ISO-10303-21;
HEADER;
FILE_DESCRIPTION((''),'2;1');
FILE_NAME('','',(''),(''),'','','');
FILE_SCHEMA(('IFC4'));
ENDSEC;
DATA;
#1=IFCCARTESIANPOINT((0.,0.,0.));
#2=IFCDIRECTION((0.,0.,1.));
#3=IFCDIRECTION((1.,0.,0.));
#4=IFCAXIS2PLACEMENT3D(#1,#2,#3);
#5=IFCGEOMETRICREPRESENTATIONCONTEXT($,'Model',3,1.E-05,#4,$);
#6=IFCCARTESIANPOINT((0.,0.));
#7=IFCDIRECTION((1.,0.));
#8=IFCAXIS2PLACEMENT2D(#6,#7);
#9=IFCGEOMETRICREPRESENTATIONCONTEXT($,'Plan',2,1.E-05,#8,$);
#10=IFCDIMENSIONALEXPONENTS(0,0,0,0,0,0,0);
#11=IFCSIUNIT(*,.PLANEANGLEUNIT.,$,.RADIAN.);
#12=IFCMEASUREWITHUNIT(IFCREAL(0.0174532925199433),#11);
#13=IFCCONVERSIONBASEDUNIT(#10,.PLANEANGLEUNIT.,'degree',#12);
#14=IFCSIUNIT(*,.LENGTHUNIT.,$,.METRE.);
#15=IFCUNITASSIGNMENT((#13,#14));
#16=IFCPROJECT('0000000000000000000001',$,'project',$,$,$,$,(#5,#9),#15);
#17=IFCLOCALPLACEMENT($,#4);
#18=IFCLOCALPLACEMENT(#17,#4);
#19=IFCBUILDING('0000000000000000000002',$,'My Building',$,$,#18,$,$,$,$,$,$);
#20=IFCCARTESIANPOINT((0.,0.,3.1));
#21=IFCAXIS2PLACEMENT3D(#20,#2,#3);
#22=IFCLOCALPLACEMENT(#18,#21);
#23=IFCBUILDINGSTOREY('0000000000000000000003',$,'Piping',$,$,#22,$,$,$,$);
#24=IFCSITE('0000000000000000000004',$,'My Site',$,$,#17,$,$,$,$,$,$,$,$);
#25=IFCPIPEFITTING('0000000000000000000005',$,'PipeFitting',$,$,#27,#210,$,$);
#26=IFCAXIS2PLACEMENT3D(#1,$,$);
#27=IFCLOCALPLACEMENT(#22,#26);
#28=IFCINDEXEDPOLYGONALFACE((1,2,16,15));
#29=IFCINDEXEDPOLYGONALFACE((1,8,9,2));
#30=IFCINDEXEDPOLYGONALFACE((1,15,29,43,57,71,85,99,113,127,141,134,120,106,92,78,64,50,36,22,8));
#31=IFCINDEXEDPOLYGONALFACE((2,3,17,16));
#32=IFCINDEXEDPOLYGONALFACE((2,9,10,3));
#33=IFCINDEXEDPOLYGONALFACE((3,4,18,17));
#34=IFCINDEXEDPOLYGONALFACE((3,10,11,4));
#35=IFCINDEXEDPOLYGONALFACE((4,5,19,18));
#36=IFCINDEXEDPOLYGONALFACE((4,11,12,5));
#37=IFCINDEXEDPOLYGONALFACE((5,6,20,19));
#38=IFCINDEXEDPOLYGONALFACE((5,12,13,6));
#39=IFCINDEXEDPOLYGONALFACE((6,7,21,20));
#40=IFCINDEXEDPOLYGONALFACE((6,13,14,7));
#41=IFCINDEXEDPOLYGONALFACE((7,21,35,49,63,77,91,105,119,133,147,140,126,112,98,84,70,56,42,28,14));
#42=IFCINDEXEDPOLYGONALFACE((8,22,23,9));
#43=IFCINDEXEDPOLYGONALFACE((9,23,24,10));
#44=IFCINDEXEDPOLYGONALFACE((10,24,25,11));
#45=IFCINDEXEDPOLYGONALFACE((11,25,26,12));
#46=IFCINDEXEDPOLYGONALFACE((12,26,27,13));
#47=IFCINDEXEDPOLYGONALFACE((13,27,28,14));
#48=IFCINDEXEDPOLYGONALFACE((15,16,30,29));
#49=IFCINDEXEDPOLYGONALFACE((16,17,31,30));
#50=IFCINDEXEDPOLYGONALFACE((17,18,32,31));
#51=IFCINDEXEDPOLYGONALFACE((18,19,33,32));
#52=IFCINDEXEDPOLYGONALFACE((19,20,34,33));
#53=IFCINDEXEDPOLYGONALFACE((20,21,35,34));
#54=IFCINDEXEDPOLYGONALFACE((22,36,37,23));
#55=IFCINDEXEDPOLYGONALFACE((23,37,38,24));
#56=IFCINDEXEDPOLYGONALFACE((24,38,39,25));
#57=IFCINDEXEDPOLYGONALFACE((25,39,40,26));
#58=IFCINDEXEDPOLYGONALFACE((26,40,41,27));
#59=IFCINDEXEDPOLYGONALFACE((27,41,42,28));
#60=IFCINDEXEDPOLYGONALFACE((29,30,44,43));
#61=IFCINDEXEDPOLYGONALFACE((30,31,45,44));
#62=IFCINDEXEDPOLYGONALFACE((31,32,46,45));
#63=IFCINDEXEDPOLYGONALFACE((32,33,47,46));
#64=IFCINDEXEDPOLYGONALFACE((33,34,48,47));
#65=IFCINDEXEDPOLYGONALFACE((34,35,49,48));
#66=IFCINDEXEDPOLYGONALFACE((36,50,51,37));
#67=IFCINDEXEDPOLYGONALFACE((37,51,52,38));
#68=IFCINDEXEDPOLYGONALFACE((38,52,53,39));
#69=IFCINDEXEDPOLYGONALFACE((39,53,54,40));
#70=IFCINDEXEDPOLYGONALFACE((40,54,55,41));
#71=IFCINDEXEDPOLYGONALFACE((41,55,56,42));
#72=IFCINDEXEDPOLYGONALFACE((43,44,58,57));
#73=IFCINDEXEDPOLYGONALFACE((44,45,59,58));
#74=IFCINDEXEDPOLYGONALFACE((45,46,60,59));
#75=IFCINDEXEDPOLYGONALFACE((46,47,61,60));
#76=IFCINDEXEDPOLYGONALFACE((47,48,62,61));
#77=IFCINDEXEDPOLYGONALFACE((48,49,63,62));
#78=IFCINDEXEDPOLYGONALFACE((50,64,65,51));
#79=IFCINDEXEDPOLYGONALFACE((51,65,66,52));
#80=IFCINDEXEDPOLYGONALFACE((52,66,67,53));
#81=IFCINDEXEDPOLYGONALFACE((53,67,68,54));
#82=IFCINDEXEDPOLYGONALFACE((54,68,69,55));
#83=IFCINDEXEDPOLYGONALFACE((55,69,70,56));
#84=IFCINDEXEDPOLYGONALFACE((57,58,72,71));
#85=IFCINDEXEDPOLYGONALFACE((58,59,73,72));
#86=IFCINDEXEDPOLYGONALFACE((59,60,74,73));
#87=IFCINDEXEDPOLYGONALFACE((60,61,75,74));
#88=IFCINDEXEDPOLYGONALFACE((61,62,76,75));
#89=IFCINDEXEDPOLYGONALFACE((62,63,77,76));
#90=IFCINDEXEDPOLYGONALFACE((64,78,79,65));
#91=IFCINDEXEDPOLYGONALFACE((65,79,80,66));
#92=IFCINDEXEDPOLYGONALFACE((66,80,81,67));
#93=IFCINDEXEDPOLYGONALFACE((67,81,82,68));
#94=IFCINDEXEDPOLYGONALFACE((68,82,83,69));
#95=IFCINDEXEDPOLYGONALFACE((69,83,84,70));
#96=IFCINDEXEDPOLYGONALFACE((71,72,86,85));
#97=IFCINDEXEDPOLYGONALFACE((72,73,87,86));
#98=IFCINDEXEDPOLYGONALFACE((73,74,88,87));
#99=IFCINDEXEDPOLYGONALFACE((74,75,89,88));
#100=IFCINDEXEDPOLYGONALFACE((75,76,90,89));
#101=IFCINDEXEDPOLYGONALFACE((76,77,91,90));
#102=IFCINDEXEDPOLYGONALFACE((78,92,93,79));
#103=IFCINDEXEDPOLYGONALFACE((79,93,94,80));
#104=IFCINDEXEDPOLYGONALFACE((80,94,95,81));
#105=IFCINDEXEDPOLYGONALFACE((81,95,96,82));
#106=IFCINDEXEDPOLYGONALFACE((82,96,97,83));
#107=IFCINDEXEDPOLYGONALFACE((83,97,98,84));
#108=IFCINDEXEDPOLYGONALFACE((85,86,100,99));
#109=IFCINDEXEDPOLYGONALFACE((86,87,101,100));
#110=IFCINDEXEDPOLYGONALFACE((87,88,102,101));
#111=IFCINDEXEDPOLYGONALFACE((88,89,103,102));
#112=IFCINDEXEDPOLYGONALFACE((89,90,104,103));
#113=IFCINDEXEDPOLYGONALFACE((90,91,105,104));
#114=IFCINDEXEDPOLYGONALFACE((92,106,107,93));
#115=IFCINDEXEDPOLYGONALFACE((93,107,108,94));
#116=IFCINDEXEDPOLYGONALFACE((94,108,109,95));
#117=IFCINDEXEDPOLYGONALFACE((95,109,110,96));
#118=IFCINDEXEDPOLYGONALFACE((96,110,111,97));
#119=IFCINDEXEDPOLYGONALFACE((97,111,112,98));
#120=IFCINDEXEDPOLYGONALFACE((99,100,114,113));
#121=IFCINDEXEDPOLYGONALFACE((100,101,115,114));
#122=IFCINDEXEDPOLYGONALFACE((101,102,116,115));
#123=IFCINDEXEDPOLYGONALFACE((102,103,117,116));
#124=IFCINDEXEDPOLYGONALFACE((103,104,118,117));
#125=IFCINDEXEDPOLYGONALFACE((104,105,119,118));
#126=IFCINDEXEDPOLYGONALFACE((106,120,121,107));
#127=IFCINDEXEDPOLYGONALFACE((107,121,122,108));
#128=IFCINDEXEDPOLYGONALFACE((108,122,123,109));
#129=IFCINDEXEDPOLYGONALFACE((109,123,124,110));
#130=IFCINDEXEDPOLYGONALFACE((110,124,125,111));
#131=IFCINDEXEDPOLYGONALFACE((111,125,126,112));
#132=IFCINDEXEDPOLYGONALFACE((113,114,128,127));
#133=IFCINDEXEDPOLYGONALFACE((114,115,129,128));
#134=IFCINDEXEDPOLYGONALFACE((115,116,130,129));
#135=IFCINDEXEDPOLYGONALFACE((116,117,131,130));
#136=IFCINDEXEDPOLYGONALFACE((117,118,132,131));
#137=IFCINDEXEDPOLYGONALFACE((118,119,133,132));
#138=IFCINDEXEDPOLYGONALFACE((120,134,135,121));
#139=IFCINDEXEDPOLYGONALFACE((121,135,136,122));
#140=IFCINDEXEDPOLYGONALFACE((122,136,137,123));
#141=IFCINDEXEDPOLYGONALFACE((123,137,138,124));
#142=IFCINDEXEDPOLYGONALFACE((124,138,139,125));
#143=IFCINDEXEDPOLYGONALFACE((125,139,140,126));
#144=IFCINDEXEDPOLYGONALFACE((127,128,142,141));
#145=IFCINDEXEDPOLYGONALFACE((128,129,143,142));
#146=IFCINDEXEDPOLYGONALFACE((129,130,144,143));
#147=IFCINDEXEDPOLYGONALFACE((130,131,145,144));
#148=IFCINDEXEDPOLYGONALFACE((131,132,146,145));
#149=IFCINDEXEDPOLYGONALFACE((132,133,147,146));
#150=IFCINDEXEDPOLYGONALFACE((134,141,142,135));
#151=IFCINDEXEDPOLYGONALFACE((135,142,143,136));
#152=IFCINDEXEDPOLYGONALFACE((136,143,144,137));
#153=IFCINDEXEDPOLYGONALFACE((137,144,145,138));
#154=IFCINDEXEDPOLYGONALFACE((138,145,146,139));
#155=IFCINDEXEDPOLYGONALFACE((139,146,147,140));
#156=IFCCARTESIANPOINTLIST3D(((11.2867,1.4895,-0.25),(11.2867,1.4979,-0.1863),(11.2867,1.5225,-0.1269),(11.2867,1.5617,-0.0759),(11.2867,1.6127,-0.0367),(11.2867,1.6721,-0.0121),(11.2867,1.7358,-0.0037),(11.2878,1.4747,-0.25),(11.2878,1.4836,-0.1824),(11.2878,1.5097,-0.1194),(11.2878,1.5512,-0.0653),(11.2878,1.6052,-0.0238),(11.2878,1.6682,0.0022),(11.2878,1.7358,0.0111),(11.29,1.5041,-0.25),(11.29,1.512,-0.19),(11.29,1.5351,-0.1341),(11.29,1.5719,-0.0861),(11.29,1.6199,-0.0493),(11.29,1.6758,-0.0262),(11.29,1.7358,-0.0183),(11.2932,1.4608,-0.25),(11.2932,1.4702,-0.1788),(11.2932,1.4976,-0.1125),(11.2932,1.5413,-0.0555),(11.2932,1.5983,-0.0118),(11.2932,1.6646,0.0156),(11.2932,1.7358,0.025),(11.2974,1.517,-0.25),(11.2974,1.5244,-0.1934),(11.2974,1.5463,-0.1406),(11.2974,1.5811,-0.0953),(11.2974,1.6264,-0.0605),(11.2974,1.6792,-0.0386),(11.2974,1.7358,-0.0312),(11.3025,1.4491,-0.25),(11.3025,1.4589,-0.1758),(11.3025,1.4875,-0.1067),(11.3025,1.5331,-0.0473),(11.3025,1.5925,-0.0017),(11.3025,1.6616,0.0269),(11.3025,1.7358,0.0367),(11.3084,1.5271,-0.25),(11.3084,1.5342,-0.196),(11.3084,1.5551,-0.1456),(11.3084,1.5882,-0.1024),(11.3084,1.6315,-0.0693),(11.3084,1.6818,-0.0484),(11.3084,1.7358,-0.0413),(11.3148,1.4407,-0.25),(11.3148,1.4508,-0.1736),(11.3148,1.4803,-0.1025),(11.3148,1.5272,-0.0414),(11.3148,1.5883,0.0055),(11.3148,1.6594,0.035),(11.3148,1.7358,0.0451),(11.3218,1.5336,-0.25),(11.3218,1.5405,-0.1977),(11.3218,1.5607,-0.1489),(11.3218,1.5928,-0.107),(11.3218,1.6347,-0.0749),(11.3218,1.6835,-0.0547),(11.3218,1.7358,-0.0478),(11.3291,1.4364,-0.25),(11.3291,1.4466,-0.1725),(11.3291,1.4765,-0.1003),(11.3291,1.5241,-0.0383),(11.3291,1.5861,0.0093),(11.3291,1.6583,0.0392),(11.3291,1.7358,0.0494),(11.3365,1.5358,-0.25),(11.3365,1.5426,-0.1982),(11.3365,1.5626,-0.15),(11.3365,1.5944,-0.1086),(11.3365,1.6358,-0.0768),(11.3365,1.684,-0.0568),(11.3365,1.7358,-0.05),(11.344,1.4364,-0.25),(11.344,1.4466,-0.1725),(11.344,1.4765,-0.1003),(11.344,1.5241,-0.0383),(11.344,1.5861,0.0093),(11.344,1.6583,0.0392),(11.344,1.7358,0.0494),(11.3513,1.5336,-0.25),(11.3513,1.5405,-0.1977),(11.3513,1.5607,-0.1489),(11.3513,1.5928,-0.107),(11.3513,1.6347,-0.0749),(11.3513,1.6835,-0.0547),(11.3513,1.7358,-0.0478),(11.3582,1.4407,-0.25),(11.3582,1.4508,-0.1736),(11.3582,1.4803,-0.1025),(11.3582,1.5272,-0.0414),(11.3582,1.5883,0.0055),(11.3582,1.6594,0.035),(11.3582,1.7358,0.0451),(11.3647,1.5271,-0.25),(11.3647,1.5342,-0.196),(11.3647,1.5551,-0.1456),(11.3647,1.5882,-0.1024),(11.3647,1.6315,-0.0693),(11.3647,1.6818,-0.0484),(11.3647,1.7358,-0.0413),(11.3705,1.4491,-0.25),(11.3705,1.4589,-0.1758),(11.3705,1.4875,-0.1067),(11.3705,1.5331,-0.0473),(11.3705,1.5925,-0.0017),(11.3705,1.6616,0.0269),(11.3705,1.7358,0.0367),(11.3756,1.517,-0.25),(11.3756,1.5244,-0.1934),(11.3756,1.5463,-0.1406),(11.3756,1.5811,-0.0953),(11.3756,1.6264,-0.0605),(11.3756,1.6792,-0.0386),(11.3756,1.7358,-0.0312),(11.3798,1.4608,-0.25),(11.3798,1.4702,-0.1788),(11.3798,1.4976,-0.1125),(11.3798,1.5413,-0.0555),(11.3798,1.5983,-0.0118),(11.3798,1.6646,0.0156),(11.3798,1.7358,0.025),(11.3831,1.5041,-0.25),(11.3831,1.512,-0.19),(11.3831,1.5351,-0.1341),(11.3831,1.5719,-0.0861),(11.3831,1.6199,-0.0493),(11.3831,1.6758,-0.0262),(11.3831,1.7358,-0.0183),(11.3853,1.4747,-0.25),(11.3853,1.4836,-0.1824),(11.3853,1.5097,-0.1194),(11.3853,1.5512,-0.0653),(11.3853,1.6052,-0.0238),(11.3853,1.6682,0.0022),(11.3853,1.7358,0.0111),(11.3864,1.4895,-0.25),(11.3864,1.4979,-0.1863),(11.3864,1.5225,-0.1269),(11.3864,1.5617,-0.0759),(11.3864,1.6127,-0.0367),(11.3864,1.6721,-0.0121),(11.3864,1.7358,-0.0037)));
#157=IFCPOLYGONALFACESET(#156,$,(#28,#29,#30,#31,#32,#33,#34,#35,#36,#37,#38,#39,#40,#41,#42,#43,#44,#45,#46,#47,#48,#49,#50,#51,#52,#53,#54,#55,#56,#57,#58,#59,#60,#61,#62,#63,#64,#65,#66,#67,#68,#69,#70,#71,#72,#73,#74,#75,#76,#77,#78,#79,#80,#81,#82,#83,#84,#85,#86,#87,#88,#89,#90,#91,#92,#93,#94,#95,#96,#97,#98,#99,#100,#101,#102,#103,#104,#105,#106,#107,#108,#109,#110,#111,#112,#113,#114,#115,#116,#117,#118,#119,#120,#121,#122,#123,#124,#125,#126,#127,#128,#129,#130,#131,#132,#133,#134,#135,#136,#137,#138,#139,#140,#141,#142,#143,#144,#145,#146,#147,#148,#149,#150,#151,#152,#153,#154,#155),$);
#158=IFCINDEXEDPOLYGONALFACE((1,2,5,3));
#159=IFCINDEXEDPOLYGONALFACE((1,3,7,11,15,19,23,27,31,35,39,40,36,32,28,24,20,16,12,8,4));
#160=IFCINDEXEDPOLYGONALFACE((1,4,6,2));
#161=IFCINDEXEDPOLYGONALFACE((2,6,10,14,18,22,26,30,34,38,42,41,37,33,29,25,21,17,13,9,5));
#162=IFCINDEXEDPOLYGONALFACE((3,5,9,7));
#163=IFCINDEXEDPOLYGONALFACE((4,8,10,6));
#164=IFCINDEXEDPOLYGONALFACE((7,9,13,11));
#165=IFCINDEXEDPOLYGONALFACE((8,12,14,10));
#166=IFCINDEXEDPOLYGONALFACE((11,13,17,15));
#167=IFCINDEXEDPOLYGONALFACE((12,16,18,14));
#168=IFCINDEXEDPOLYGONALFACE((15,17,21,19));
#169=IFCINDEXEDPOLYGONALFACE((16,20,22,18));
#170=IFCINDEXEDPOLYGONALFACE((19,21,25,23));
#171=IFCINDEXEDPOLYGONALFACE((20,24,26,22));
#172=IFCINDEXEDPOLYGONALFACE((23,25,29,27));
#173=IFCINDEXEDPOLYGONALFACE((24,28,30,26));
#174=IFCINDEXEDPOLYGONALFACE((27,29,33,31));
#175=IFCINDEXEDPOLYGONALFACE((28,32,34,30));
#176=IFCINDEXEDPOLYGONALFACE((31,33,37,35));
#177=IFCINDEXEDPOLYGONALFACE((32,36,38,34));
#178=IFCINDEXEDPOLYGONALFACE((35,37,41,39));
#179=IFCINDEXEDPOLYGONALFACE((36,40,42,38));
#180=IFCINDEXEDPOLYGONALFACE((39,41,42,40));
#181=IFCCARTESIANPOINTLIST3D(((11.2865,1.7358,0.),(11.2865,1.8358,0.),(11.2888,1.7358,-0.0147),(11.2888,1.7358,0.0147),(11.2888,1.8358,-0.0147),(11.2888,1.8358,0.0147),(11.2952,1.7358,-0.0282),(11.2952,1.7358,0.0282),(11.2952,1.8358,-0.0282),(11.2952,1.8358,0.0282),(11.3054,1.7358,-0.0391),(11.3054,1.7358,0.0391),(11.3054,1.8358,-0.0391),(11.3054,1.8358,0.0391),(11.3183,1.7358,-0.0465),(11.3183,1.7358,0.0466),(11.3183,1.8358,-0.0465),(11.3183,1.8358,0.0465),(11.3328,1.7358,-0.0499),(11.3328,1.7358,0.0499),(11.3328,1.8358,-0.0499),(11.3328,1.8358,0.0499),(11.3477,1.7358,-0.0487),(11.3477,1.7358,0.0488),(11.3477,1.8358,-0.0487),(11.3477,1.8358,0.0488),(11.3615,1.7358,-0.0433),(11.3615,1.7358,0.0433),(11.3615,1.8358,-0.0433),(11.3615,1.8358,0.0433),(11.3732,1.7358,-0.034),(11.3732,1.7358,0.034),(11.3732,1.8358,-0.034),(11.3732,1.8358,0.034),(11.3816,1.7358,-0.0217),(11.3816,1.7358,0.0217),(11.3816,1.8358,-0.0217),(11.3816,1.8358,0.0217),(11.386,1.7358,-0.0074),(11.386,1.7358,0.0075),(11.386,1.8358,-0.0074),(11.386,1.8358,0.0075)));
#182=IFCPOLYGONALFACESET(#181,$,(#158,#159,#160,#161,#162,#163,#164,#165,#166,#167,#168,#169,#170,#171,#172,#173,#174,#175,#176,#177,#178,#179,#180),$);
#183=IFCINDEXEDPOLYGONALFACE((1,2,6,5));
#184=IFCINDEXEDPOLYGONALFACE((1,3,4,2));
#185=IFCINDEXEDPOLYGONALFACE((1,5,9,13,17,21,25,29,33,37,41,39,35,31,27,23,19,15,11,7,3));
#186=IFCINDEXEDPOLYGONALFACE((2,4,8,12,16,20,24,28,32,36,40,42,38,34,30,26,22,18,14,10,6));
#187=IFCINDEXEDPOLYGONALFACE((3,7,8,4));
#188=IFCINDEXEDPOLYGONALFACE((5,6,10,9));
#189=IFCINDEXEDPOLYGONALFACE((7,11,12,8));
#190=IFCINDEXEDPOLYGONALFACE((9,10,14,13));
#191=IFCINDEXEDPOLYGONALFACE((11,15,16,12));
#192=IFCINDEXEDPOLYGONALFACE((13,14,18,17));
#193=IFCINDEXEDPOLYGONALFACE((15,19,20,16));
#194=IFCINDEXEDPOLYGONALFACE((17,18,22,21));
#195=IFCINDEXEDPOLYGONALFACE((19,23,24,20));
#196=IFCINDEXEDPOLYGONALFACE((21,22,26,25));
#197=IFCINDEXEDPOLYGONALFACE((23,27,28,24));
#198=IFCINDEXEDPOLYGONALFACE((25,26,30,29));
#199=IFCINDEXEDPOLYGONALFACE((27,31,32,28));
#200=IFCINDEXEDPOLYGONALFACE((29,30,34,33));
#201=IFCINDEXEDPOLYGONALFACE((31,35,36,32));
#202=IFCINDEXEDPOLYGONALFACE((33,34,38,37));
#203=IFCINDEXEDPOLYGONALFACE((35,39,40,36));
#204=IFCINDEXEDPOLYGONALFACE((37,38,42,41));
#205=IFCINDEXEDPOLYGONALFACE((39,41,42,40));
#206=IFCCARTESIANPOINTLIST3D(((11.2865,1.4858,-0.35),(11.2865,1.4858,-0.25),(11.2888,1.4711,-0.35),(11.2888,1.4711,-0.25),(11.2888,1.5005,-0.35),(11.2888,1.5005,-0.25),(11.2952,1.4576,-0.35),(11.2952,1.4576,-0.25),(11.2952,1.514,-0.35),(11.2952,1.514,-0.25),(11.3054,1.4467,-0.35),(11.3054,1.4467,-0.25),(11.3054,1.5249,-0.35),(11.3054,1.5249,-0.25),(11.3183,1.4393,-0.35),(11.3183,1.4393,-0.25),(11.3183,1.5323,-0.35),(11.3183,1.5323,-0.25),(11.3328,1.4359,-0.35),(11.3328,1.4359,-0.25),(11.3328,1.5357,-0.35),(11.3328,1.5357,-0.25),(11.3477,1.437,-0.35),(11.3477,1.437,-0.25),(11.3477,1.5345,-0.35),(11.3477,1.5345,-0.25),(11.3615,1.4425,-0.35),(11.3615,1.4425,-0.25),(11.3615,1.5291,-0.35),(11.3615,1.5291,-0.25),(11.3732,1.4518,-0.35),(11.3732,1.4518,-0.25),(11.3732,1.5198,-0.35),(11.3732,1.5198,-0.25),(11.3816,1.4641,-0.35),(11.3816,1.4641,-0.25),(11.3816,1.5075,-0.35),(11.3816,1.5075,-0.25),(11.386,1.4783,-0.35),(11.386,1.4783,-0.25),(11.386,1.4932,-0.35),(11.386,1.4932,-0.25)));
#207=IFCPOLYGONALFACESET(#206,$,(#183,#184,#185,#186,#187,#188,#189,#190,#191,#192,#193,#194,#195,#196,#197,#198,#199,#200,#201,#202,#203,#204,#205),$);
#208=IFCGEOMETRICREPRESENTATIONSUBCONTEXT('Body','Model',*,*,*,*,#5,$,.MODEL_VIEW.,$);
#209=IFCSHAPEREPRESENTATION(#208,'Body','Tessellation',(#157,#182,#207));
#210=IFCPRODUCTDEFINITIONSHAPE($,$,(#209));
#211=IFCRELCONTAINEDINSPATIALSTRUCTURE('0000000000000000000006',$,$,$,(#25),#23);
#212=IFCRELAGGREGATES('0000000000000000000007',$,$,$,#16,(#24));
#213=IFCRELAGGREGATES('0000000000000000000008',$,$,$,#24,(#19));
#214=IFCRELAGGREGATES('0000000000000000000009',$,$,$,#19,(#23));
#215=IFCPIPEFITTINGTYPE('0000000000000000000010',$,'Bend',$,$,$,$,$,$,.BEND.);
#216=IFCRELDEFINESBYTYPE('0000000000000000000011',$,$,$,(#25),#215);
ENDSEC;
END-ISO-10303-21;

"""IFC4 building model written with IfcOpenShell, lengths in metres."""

from ifc_helpers import new_model, entity, si_unit, converted_unit, frame, origin_with_axes, origin_2d_with_axis, place, context, subcontext, project, spatial, circle, extrude, source, transform, mapped, type_object, type_shapes, element, save


model = new_model("IFC4")

# Units and contexts
model_context = context("Model", 3, precision=1e-05, world=origin_with_axes())
plan_context = context("Plan", 2, precision=1e-05, world=origin_2d_with_axis())
body_context = subcontext(model_context, "Body", "Model", "MODEL_VIEW")
ifc_project = project(units=[converted_unit("PLANEANGLEUNIT", "degree", entity("IfcReal", 0.0174532925199433), si_unit("PLANEANGLEUNIT", "RADIAN"), dimensions=[0, 0, 0, 0, 0, 0, 0]), si_unit("LENGTHUNIT", "METRE")], contexts=[model_context, plan_context])

# Site, building, storey
site_placement = place(None, origin_with_axes())
site = spatial("IfcSite", under=ifc_project, at=site_placement, Name="My Site")
building_placement = place(site_placement, origin_with_axes())
building = spatial("IfcBuilding", under=site, at=building_placement, Name="My Building")
storey_placement = place(building_placement, frame((0.0, 0.0, 3.1), z_axis=(0.0, 0.0, 1.0), x_axis=(1.0, 0.0, 0.0)))
storey = spatial("IfcBuildingStorey", under=building, at=storey_placement, Name="Piping")

# Pipe fitting
pipe_fitting_type_1 = type_object("IfcPipeFittingType", Name="Bend", PredefinedType="BEND")
shared_shape_1 = source(origin_with_axes(), body_context, "Body", "SolidModel", [
    entity("IfcSweptDiskSolid", entity("IfcIndexedPolyCurve", entity("IfcCartesianPointList3D", [[0.0, 0.0, -0.1], [0.0, -0.0732, -0.2768], [0.0, -0.25, -0.35]]), [entity("IfcArcIndex", [1, 2, 3])]), 0.05),
    extrude(circle(Radius=0.05), origin_with_axes(), (0.0, 0.0, -1.0), 0.1),
    extrude(circle(Radius=0.05), frame((0.0, -0.25, -0.35), z_axis=(0.0, -1.0, 0.000022), x_axis=(1.0, 0.0, 0.0)), (0.0, 0.0, 1.0), 0.1),
])
type_shapes(pipe_fitting_type_1, [shared_shape_1])
for number, where, z_axis, x_axis, name in (
    (1, (11.3365, 1.8358, 0.0), (0.0, 1.0, -0.000022), (-1.0, 0.0, 0.0), "PipeFitting"),
):
    element("IfcPipeFitting", number, at=place(storey_placement, frame(where, z_axis=z_axis, x_axis=x_axis)), inside=storey, type_object=pipe_fitting_type_1, Name=name, context=body_context, shape_type="MappedRepresentation", body=[
        mapped(shared_shape_1, transform((0.0, 0.0, 0.0), x_axis=(1.0, 0.0, 0.0), y_axis=(0.0, 1.0, 0.0), z_axis=(0.0, 0.0, 1.0), scale=1.0)),
    ])

save(model, "model.ifc")
